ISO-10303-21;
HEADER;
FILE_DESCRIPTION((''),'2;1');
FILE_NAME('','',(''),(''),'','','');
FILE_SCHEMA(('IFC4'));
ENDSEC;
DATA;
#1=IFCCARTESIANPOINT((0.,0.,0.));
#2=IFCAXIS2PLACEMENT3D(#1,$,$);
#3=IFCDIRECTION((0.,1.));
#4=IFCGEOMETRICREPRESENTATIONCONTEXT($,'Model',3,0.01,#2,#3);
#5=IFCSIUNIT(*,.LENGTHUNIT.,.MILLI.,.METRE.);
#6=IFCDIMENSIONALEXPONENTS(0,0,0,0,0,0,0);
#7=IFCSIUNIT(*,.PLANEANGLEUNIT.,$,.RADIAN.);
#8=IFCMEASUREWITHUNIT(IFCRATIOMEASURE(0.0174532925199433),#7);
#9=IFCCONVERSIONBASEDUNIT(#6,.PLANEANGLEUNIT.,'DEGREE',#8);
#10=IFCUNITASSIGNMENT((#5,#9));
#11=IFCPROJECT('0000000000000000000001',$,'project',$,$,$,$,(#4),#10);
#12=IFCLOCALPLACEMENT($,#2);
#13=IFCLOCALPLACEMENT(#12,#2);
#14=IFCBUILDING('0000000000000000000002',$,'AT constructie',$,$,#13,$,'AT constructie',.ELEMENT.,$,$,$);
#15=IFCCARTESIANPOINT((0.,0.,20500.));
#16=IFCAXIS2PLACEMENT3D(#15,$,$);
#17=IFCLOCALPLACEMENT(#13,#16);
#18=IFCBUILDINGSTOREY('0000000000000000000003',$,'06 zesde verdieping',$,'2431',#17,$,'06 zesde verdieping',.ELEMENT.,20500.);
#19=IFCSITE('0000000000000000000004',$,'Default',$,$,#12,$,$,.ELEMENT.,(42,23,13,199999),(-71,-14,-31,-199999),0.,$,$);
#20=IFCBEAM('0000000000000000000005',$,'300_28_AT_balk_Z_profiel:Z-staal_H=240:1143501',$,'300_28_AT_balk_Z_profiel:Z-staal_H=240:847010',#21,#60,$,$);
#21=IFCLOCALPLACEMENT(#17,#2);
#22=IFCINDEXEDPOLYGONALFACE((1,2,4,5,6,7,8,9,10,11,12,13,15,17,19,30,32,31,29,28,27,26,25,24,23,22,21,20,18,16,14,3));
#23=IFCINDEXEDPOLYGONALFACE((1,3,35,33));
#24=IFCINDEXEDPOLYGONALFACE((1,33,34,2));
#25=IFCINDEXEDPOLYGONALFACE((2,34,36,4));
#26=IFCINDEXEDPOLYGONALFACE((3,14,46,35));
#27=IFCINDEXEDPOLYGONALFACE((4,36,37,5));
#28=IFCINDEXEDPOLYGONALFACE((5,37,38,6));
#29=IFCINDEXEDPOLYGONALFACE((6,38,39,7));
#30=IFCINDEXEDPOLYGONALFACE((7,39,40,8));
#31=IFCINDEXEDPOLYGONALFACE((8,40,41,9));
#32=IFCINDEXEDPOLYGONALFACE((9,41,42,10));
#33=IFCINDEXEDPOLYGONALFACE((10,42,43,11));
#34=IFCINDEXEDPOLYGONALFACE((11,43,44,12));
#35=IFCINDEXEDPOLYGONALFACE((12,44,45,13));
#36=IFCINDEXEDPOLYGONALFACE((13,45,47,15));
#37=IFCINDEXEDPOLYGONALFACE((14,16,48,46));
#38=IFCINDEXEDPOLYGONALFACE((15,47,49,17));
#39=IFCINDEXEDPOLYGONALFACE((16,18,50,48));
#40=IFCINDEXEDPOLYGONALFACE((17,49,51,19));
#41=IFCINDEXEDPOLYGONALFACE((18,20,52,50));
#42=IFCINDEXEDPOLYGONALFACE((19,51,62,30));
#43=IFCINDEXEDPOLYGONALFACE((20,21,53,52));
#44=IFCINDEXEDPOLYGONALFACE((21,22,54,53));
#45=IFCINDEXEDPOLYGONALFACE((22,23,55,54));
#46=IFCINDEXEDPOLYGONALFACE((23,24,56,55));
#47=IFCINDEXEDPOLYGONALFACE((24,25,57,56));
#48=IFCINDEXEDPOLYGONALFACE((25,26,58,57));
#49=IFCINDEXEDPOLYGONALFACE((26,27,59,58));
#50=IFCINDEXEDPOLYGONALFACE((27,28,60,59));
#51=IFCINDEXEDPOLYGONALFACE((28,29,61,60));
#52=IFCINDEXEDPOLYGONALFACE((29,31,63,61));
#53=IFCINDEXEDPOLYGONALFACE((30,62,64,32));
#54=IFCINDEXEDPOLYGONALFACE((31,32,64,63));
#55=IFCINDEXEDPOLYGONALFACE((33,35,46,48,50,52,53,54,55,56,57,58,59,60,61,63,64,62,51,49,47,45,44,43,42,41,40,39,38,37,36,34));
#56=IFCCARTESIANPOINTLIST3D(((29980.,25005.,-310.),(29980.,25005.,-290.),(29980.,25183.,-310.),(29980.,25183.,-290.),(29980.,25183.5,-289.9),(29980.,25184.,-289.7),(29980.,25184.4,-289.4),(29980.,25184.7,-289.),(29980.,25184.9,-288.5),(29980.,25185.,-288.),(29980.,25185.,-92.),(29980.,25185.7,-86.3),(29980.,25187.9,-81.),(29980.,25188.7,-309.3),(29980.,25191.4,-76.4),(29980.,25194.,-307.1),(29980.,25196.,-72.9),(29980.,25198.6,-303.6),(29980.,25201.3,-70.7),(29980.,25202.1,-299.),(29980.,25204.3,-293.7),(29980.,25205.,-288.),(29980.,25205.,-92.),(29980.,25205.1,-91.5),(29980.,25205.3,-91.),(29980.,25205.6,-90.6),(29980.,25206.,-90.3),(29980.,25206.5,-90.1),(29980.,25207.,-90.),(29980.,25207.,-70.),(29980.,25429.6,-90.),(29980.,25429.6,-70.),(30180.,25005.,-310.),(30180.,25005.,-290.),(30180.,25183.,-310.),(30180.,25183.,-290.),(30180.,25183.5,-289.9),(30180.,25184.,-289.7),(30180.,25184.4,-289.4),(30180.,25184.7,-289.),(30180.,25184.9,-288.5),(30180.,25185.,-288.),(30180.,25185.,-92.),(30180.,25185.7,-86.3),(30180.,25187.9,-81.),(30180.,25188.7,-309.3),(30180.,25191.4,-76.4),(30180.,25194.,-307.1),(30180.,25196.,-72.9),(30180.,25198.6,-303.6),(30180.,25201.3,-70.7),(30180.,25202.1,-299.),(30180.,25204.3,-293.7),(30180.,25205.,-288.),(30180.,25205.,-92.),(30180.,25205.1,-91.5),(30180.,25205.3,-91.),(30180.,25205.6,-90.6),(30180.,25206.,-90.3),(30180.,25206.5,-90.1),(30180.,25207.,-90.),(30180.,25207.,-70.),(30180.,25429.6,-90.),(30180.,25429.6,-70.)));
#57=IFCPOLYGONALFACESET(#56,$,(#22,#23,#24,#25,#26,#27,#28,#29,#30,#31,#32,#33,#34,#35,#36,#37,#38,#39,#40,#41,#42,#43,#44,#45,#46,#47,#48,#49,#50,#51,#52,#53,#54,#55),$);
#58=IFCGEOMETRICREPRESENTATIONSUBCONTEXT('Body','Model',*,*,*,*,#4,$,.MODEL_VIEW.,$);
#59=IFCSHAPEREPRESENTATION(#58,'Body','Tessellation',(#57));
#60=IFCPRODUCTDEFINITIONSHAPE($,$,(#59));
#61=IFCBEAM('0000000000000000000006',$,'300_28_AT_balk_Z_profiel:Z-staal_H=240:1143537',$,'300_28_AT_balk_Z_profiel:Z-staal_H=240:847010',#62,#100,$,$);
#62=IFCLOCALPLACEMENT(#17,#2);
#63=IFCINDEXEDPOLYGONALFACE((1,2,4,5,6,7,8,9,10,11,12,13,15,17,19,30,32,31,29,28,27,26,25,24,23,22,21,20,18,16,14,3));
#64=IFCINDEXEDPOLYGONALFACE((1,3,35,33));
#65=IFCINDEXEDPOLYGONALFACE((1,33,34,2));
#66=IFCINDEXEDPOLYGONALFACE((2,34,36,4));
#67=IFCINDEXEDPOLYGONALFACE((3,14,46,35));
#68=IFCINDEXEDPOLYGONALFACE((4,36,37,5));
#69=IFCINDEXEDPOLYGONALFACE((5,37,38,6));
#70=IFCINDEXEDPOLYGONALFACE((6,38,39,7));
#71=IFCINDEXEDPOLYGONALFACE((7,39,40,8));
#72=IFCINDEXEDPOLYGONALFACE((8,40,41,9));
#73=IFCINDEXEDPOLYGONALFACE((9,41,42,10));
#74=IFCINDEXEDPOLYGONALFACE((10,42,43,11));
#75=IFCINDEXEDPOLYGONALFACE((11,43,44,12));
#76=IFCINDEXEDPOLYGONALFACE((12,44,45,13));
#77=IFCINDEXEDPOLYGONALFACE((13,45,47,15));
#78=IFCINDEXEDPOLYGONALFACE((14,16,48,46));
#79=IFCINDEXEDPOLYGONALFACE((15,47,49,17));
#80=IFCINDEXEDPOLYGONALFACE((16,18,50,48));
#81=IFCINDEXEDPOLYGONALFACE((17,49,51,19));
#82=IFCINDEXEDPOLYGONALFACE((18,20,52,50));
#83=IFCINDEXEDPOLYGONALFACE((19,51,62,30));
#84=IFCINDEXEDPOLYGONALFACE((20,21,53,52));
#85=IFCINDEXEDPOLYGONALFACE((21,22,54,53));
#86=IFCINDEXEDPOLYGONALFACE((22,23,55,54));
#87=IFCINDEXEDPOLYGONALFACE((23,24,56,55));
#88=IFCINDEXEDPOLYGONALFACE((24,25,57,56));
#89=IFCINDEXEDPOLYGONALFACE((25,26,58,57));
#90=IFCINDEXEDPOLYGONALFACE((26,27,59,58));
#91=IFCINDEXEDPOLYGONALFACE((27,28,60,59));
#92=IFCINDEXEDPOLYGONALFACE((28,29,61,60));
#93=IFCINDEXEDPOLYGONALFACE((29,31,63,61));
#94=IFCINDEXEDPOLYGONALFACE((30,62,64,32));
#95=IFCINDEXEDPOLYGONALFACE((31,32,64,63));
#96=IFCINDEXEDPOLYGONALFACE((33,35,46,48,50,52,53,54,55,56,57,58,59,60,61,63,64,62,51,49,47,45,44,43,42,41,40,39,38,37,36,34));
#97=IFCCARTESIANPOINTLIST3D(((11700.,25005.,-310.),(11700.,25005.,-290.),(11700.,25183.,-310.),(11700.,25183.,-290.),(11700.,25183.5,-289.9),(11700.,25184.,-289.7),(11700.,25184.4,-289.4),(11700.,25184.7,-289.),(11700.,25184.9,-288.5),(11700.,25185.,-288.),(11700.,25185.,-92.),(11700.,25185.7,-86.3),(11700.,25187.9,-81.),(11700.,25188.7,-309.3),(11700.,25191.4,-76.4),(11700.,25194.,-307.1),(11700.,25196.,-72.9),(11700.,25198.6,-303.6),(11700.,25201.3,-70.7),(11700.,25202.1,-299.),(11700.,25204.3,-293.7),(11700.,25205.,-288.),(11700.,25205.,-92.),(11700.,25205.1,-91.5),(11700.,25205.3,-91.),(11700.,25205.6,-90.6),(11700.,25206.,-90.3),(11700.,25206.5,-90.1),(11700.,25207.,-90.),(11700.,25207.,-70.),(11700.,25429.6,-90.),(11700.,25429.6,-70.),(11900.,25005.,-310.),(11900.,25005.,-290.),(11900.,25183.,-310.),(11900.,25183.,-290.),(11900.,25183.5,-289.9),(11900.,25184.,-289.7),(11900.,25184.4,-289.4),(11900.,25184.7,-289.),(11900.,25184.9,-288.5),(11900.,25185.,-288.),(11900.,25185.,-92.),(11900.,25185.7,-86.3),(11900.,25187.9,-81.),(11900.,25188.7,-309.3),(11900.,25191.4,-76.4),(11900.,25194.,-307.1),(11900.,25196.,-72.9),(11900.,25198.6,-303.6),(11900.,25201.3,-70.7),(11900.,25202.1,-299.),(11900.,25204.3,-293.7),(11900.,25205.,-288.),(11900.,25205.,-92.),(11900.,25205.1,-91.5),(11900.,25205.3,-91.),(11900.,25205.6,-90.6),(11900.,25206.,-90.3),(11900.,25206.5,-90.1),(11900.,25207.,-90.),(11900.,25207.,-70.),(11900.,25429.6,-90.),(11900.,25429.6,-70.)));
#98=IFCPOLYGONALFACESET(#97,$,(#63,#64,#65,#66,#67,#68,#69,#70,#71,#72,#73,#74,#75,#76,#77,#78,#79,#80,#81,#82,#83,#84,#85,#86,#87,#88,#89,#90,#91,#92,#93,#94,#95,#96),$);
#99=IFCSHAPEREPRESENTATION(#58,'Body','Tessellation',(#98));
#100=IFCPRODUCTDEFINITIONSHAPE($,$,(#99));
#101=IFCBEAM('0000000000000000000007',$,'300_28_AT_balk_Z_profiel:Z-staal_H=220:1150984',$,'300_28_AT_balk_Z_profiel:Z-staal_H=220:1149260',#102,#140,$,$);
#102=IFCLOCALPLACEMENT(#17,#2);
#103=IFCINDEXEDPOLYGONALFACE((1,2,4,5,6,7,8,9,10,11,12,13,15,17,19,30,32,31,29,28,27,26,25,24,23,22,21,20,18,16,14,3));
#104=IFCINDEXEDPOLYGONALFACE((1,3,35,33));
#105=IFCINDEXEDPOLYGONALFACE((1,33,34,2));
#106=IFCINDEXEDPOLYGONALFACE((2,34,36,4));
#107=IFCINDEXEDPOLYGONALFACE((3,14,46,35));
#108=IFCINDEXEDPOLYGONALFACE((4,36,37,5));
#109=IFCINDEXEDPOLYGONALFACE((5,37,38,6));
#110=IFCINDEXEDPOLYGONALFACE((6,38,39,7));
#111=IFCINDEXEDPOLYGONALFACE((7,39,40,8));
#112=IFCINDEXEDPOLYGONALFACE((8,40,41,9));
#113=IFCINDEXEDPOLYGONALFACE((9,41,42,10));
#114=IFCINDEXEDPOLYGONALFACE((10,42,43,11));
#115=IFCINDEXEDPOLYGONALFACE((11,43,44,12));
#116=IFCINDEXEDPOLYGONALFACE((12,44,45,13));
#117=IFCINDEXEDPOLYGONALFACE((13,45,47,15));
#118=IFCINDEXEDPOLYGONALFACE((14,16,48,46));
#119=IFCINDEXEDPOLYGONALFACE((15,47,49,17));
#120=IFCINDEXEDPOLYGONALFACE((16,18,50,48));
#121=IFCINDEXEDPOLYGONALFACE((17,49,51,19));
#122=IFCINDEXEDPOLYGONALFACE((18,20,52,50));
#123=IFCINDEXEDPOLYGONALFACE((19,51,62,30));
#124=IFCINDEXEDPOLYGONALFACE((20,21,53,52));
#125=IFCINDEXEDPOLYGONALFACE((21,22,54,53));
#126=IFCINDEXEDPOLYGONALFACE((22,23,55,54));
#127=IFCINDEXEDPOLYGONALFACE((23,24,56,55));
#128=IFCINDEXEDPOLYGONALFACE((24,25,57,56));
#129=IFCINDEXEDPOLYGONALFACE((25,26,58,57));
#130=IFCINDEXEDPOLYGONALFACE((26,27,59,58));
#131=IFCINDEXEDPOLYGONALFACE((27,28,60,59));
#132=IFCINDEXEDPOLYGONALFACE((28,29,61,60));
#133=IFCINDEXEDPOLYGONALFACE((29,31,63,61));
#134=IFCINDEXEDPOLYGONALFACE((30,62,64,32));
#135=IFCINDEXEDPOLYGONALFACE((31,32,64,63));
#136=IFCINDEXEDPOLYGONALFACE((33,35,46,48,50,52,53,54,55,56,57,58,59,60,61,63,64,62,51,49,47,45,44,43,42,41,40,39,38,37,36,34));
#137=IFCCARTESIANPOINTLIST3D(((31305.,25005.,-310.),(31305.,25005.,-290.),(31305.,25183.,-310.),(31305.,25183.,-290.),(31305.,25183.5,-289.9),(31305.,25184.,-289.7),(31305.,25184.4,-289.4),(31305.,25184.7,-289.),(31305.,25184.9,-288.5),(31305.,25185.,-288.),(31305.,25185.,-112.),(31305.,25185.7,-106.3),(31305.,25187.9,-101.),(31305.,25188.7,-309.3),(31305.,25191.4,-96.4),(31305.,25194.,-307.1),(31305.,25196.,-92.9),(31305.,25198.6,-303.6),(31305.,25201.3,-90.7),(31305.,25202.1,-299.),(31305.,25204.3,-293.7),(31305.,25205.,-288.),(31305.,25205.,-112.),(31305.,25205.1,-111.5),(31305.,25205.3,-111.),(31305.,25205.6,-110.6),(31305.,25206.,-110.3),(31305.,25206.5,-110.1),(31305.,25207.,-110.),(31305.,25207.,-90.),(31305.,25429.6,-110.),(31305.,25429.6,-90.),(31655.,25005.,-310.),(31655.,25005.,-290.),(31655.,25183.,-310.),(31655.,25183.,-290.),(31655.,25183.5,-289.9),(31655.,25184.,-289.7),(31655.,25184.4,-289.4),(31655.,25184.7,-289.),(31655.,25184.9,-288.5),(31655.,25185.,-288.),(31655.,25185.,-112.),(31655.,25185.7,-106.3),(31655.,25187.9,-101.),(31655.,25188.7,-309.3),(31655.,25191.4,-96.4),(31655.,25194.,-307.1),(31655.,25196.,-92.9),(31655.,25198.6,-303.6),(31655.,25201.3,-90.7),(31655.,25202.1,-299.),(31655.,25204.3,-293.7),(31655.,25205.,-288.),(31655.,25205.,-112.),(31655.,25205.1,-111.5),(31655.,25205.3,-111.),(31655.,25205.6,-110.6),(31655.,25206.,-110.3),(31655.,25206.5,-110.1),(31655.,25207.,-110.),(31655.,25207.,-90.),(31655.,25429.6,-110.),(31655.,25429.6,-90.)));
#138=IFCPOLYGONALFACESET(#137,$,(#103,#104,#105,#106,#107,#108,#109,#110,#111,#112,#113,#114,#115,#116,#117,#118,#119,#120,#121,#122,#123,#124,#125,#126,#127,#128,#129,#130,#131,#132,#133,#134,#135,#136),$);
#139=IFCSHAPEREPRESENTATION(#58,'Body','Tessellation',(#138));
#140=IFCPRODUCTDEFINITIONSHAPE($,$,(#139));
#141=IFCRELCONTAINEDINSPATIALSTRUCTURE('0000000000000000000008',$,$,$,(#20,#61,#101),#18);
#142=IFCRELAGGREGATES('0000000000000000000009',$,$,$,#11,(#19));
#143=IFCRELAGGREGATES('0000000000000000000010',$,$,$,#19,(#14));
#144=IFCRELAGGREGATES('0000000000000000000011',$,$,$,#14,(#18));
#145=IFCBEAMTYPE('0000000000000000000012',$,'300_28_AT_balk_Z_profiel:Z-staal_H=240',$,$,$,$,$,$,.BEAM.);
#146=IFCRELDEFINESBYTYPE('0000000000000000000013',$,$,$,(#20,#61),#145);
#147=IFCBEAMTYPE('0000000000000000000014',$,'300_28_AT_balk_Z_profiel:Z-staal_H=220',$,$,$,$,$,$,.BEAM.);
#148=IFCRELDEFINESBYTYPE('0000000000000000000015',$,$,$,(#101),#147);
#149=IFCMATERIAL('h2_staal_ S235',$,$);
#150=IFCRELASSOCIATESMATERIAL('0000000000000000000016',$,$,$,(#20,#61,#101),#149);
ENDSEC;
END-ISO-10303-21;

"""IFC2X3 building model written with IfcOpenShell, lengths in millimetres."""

from ifc_helpers import new_model, entity, si_unit, converted_unit, direction, frame, frame_2d, origin, place, context, subcontext, project, spatial, polyline, circle_curve, parameter, trimmed, segment, composite_curve, outline, extrude, material, type_object, element, save


model = new_model("IFC2X3")

# Units and contexts
model_context = context("Model", 3, precision=0.01, world=origin(), true_north=direction((0.0, 1.0)))
body_context = subcontext(model_context, "Body", "Model", "MODEL_VIEW")
ifc_project = project(units=[si_unit("LENGTHUNIT", "METRE", prefix="MILLI"), converted_unit("PLANEANGLEUNIT", "DEGREE", entity("IfcRatioMeasure", 0.0174532925199433), si_unit("PLANEANGLEUNIT", "RADIAN"), dimensions=[0, 0, 0, 0, 0, 0, 0])], contexts=[model_context])

# Site, building, storey
site_placement = place(None, origin())
site = spatial("IfcSite", under=ifc_project, at=site_placement, Name="Default", CompositionType="ELEMENT", RefLatitude=(42, 23, 13, 199999), RefLongitude=(-71, -14, -31, -199999), RefElevation=0.0)
building_placement = place(site_placement, origin())
building = spatial("IfcBuilding", under=site, at=building_placement, Name="AT constructie", LongName="AT constructie", CompositionType="ELEMENT")
storey_placement = place(building_placement, frame((0.0, 0.0, 20500.0)))
storey = spatial("IfcBuildingStorey", under=building, at=storey_placement, Name="06 zesde verdieping", ObjectType="2431", LongName="06 zesde verdieping", CompositionType="ELEMENT", Elevation=20500.0)

# Beams
ifc_material_1 = material(Name="h2_staal_ S235")
beam_type_1 = type_object("IfcBeamType", Name="300_28_AT_balk_Z_profiel:Z-staal_H=240", PredefinedType="BEAM")
for number, where, name in (
    (1, (29980.0, 25205.0, -70.0), "300_28_AT_balk_Z_profiel:Z-staal_H=240:1143501"),
    (2, (11700.0, 25205.0, -70.0), "300_28_AT_balk_Z_profiel:Z-staal_H=240:1143537"),
):
    element("IfcBeam", number, at=place(storey_placement, frame(where)), inside=storey, type_object=beam_type_1, material=ifc_material_1, Name=name, ObjectType="300_28_AT_balk_Z_profiel:Z-staal_H=240:847010", context=body_context, shape_type="SweptSolid", body=[
        extrude(outline(composite_curve([segment(polyline([(100.0, -197.4), (120.0, -197.4)]), True, "CONTINUOUS"), segment(polyline([(120.0, -197.4), (120.0, -19.4)]), True, "CONTINUOUS"), segment(trimmed(circle_curve(frame_2d((98.0, -19.4), x_axis=(1.0, 0.0)), 22.0), [parameter(0.0)], [parameter(90.0)], True, "PARAMETER"), True, "CONTINUOUS"), segment(polyline([(98.0, 2.6), (-98.0, 2.6)]), True, "CONTINUOUS"), segment(trimmed(circle_curve(frame_2d((-98.0, 4.6), x_axis=(0.0, -1.0)), 2.0), [parameter(270.0)], [parameter(0.0)], True, "PARAMETER"), False, "CONTINUOUS"), segment(polyline([(-100.0, 4.6), (-100.0, 227.2)]), True, "CONTINUOUS"), segment(polyline([(-100.0, 227.2), (-120.0, 227.2)]), True, "CONTINUOUS"), segment(polyline([(-120.0, 227.2), (-120.0, 4.6)]), True, "CONTINUOUS"), segment(trimmed(circle_curve(frame_2d((-98.0, 4.6), x_axis=(-1.0, 0.0)), 22.0), [parameter(0.0)], [parameter(90.0)], True, "PARAMETER"), True, "CONTINUOUS"), segment(polyline([(-98.0, -17.4), (98.0, -17.4)]), True, "CONTINUOUS"), segment(trimmed(circle_curve(frame_2d((98.0, -19.4), x_axis=(0.0, 1.0)), 2.0), [parameter(270.0)], [parameter(0.0)], True, "PARAMETER"), False, "CONTINUOUS"), segment(polyline([(100.0, -19.4), (100.0, -197.4)]), True, "CONTINUOUS")], self_intersect=False)), frame((0.0, -2.6, -120.0), z_axis=(1.0, 0.0, 0.0), x_axis=(0.0, 0.0, -1.0)), (0.0, 0.0, 1.0), 200.0),
    ])
beam_type_2 = type_object("IfcBeamType", Name="300_28_AT_balk_Z_profiel:Z-staal_H=220", PredefinedType="BEAM")
beam_1_placement = place(storey_placement, frame((30520.0, 25205.0, -90.0)))
element("IfcBeam", 3, at=beam_1_placement, inside=storey, type_object=beam_type_2, material=ifc_material_1, Name="300_28_AT_balk_Z_profiel:Z-staal_H=220:1150984", ObjectType="300_28_AT_balk_Z_profiel:Z-staal_H=220:1149260", context=body_context, shape_type="SweptSolid", body=[
    extrude(outline(composite_curve([segment(polyline([(90.0, -197.4), (110.0, -197.4)]), True, "CONTINUOUS"), segment(polyline([(110.0, -197.4), (110.0, -19.4)]), True, "CONTINUOUS"), segment(trimmed(circle_curve(frame_2d((88.0, -19.4), x_axis=(1.0, 0.0)), 22.0), [parameter(0.0)], [parameter(90.0)], True, "PARAMETER"), True, "CONTINUOUS"), segment(polyline([(88.0, 2.6), (-88.0, 2.6)]), True, "CONTINUOUS"), segment(trimmed(circle_curve(frame_2d((-88.0, 4.6), x_axis=(0.0, -1.0)), 2.0), [parameter(270.0)], [parameter(0.0)], True, "PARAMETER"), False, "CONTINUOUS"), segment(polyline([(-90.0, 4.6), (-90.0, 227.2)]), True, "CONTINUOUS"), segment(polyline([(-90.0, 227.2), (-110.0, 227.2)]), True, "CONTINUOUS"), segment(polyline([(-110.0, 227.2), (-110.0, 4.6)]), True, "CONTINUOUS"), segment(trimmed(circle_curve(frame_2d((-88.0, 4.6), x_axis=(-1.0, 0.0)), 22.0), [parameter(0.0)], [parameter(90.0)], True, "PARAMETER"), True, "CONTINUOUS"), segment(polyline([(-88.0, -17.4), (88.0, -17.4)]), True, "CONTINUOUS"), segment(trimmed(circle_curve(frame_2d((88.0, -19.4), x_axis=(0.0, 1.0)), 2.0), [parameter(270.0)], [parameter(0.0)], True, "PARAMETER"), False, "CONTINUOUS"), segment(polyline([(90.0, -19.4), (90.0, -197.4)]), True, "CONTINUOUS")], self_intersect=False)), frame((785.0, -2.6, -110.0), z_axis=(1.0, 0.0, 0.0), x_axis=(0.0, 0.0, -1.0)), (0.0, 0.0, 1.0), 350.0),
])

save(model, "model.ifc")
